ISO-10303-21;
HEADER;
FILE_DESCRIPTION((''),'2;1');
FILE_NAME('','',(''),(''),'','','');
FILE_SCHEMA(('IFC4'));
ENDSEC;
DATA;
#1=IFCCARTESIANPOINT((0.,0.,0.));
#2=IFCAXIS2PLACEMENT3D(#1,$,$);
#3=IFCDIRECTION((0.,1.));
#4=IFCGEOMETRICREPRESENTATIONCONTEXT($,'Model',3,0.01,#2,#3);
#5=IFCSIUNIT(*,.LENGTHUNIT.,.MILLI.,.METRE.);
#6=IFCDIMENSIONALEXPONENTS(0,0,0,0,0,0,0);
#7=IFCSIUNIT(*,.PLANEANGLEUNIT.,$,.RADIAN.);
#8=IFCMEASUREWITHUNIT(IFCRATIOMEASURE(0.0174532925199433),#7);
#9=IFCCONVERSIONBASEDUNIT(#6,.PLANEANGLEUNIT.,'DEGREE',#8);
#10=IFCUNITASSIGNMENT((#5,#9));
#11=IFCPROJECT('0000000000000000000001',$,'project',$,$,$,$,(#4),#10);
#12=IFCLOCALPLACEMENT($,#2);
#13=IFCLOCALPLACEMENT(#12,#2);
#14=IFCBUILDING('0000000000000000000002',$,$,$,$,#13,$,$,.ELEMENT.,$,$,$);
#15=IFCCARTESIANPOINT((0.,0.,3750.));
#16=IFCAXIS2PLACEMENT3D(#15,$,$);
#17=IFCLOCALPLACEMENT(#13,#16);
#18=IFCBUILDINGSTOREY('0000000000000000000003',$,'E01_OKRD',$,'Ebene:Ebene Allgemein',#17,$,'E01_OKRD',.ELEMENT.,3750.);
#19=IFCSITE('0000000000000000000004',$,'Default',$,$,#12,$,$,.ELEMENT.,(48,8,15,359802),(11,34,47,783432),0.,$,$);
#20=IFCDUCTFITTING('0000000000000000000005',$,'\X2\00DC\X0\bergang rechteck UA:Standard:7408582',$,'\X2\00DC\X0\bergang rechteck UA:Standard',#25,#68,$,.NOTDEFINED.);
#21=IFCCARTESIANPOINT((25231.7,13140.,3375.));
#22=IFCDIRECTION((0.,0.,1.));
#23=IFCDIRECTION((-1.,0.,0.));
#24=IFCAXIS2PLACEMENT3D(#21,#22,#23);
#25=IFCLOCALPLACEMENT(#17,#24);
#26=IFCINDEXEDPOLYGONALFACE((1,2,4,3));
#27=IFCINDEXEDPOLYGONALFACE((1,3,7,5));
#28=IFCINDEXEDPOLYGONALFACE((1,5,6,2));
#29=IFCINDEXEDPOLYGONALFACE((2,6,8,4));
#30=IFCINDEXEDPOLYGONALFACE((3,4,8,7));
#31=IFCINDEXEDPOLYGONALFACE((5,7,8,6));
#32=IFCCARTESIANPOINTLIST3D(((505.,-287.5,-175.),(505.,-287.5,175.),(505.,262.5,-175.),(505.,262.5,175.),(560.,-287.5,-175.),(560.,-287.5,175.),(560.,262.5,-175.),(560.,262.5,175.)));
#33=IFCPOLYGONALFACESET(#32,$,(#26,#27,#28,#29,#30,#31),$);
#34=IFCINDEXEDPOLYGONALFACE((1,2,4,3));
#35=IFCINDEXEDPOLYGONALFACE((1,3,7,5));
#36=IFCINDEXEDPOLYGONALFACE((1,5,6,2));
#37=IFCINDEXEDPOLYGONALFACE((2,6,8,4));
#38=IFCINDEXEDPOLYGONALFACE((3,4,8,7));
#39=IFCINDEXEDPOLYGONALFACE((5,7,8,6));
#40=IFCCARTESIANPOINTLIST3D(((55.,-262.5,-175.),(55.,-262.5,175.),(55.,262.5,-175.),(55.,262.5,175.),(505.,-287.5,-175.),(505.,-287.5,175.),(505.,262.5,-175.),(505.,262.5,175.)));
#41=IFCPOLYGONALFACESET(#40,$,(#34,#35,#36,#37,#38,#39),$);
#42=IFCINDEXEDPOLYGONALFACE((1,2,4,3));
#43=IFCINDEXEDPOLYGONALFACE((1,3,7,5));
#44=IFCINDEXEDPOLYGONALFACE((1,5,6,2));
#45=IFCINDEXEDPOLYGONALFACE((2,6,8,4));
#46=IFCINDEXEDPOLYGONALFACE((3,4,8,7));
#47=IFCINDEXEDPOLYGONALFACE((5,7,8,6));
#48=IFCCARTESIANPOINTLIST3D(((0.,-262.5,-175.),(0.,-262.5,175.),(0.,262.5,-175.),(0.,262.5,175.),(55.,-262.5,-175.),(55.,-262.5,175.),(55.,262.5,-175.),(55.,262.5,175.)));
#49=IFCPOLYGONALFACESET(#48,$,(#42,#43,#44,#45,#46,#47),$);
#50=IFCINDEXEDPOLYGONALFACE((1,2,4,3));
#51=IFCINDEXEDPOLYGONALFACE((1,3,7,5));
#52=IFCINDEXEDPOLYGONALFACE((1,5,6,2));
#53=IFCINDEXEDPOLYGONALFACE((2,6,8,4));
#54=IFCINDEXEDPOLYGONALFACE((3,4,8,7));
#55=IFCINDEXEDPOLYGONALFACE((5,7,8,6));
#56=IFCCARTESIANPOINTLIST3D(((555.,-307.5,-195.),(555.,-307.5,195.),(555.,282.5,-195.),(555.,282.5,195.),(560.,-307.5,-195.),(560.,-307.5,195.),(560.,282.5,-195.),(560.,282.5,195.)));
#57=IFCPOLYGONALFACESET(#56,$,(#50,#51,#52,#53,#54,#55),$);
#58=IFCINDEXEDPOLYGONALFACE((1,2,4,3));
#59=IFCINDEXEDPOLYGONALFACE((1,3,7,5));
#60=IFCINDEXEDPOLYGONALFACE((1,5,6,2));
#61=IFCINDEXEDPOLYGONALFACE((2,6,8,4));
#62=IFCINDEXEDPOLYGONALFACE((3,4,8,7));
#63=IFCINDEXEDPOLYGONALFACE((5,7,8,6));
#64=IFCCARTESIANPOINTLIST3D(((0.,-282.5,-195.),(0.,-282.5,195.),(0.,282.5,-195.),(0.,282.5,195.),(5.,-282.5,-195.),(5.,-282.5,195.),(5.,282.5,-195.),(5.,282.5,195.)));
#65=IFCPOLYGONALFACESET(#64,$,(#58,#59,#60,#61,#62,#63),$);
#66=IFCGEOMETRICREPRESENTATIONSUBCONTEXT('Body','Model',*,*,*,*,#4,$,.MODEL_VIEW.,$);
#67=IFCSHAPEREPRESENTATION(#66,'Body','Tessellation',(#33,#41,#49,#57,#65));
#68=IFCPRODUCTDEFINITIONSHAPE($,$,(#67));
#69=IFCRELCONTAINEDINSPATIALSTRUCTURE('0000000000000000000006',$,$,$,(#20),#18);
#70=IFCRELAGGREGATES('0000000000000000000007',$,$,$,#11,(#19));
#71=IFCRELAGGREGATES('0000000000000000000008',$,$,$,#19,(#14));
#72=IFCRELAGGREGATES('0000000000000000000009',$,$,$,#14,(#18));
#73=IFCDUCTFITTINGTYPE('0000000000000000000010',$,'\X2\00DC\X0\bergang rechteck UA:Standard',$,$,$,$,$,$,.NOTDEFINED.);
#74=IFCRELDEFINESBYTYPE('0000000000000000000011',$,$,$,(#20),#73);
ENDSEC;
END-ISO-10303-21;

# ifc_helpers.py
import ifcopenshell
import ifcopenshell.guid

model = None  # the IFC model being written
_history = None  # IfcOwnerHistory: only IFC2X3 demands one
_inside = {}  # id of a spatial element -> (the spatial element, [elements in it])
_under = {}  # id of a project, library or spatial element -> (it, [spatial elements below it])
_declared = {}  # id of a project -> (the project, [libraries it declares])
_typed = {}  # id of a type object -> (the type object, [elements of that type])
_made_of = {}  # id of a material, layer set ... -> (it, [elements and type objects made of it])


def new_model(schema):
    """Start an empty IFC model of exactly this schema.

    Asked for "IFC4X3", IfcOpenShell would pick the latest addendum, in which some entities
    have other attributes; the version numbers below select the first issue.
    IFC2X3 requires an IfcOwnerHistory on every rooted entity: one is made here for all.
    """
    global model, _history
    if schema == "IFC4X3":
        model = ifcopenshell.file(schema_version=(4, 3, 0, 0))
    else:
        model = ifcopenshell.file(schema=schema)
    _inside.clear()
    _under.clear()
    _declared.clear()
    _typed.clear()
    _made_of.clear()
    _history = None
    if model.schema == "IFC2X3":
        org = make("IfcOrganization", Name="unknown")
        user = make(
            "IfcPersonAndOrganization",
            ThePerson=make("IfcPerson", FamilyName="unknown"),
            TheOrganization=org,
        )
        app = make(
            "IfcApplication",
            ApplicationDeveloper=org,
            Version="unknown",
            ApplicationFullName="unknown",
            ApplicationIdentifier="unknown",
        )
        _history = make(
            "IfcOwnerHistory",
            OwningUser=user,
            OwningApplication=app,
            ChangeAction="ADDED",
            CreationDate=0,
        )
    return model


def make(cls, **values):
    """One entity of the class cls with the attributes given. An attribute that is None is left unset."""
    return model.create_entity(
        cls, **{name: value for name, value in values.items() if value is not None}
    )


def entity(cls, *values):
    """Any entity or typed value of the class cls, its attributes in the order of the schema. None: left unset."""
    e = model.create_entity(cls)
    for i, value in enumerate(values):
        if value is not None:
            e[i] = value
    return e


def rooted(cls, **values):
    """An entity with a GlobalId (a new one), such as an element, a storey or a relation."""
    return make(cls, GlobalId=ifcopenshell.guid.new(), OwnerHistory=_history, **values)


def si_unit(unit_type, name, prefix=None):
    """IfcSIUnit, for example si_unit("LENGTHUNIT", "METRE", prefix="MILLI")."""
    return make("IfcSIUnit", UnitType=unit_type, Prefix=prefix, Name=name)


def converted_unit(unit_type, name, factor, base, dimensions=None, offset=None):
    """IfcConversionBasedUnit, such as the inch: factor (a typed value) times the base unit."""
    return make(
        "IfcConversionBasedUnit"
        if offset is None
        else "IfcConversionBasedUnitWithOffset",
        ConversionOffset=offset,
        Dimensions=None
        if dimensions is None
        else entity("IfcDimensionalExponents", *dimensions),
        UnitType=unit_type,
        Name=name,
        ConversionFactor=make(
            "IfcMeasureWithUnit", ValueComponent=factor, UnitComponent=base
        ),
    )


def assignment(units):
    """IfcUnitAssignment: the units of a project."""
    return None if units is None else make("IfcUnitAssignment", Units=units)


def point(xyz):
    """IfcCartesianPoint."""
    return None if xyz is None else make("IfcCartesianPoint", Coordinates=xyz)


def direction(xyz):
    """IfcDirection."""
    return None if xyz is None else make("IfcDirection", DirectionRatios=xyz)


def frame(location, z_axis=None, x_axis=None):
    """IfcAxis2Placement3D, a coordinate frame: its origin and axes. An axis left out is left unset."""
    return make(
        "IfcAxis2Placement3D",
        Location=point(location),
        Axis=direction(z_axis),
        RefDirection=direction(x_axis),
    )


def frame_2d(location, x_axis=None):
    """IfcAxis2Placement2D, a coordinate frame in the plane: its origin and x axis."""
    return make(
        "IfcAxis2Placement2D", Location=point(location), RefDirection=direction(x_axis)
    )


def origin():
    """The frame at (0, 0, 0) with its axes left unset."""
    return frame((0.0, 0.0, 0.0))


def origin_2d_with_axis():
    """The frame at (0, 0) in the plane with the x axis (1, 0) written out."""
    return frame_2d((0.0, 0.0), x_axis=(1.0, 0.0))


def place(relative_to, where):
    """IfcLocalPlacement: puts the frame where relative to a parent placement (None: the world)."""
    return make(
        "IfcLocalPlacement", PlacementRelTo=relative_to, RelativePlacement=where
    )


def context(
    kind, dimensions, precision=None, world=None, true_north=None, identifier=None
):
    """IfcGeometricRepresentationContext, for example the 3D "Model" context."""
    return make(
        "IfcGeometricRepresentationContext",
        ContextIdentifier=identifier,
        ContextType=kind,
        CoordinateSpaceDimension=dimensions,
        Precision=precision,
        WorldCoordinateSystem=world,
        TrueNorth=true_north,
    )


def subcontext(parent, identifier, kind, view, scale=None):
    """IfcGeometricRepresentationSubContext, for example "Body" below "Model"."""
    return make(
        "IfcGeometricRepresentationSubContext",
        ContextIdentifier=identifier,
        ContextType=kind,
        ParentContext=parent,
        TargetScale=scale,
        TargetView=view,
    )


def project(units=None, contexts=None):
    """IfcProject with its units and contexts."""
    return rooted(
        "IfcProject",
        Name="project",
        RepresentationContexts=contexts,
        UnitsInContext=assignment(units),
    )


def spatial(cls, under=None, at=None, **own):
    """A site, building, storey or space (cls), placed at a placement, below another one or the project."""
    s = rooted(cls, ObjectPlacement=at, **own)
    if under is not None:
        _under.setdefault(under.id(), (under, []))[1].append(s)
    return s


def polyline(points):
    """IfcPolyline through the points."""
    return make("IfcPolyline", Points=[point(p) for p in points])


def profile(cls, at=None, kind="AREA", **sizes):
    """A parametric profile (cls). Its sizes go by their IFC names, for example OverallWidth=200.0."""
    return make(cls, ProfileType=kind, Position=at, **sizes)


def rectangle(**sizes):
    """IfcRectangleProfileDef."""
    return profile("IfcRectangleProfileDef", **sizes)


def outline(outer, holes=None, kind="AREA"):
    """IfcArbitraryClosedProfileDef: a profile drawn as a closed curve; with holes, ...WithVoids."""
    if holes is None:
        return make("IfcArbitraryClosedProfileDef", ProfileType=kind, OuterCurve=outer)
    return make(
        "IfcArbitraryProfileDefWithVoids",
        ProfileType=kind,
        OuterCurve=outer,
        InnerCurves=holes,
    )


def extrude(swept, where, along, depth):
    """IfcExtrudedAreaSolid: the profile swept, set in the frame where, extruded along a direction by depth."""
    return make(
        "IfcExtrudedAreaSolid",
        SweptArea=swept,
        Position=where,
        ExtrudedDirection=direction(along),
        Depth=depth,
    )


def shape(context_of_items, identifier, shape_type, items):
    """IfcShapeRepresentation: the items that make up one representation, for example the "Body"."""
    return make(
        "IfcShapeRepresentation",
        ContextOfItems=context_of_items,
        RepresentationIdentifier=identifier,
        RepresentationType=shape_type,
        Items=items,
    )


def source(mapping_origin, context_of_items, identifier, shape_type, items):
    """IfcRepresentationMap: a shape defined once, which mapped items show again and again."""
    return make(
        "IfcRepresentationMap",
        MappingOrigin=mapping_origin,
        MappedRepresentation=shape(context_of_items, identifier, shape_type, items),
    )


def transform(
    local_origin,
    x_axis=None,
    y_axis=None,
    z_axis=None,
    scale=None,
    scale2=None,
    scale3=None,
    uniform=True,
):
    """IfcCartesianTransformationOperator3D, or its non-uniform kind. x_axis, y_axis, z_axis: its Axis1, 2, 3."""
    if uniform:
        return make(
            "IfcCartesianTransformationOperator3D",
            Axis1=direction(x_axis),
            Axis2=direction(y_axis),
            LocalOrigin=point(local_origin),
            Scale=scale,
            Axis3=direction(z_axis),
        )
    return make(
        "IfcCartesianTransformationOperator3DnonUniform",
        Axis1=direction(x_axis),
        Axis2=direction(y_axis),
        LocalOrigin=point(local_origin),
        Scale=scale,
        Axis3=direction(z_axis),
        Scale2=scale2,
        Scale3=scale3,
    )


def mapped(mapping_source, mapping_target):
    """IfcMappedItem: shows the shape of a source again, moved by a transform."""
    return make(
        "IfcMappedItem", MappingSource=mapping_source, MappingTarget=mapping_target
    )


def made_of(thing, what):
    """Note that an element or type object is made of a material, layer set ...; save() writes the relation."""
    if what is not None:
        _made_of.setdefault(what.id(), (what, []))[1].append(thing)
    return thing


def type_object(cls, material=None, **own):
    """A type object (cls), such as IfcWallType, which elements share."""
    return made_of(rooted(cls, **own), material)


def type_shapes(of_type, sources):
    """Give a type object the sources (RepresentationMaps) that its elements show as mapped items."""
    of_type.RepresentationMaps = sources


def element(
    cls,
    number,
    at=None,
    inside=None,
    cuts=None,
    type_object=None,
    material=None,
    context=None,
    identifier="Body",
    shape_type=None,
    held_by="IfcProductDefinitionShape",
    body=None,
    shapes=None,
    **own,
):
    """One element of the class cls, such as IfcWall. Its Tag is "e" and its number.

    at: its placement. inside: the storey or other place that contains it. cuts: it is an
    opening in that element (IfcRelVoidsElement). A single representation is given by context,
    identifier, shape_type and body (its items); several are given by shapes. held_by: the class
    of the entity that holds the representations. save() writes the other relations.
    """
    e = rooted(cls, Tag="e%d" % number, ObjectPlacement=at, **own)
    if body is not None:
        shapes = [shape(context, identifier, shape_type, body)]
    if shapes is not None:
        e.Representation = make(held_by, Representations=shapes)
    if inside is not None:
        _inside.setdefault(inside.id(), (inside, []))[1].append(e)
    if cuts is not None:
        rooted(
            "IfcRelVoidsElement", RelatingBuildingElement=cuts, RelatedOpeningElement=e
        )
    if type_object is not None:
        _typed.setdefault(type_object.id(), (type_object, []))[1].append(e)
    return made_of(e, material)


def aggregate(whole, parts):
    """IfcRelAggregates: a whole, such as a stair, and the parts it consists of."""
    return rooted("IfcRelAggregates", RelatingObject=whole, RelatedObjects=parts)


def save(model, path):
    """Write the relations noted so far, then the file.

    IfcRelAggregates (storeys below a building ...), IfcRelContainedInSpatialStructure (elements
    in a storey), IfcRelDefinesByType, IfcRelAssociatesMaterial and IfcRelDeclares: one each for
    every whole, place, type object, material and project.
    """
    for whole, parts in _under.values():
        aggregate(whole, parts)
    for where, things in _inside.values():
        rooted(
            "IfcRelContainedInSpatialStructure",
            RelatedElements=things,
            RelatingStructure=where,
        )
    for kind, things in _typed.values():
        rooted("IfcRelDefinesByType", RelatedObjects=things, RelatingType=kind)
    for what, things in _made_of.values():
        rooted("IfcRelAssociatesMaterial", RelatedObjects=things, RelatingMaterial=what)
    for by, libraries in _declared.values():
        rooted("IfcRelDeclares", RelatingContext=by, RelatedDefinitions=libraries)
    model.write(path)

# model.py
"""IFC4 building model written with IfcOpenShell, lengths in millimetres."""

from ifc_helpers import new_model, entity, si_unit, converted_unit, direction, frame, frame_2d, origin, origin_2d_with_axis, place, context, subcontext, project, spatial, polyline, rectangle, outline, extrude, source, transform, mapped, type_object, type_shapes, element, save


model = new_model("IFC4")

# Units and contexts
model_context = context("Model", 3, precision=0.01, world=origin(), true_north=direction((0.0, 1.0)))
body_context = subcontext(model_context, "Body", "Model", "MODEL_VIEW")
ifc_project = project(units=[si_unit("LENGTHUNIT", "METRE", prefix="MILLI"), converted_unit("PLANEANGLEUNIT", "DEGREE", entity("IfcRatioMeasure", 0.0174532925199433), si_unit("PLANEANGLEUNIT", "RADIAN"), dimensions=[0, 0, 0, 0, 0, 0, 0])], contexts=[model_context])

# Site, building, storey
site_placement = place(None, origin())
site = spatial("IfcSite", under=ifc_project, at=site_placement, Name="Default", CompositionType="ELEMENT", RefLatitude=(48, 8, 15, 359802), RefLongitude=(11, 34, 47, 783432), RefElevation=0.0)
building_placement = place(site_placement, origin())
building = spatial("IfcBuilding", under=site, at=building_placement, CompositionType="ELEMENT")
storey_placement = place(building_placement, frame((0.0, 0.0, 3750.0)))
storey = spatial("IfcBuildingStorey", under=building, at=storey_placement, Name="E01_OKRD", ObjectType="Ebene:Ebene Allgemein", LongName="E01_OKRD", CompositionType="ELEMENT", Elevation=3750.0)

# Duct fitting
duct_fitting_type_1 = type_object("IfcDuctFittingType", Name="Übergang rechteck UA:Standard", PredefinedType="NOTDEFINED")
shared_shape_1 = source(origin(), body_context, "Body", "SweptSolid", [
    extrude(rectangle(XDim=55.0, YDim=550.0, at=frame_2d((0.0, 0.0), x_axis=(1.0, 0.0))), frame((532.5, -12.5, -175.0)), (0.0, 0.0, 1.0), 350.0),
    extrude(outline(polyline([(-210.4, -268.3), (240.3, -268.3), (209.7, 280.8), (-239.6, 255.9), (-210.4, -268.3)])), frame((280.0, -6.2, -175.0), z_axis=(0.0, 0.0, 1.0), x_axis=(0.99846, -0.05547, 0.0)), (0.0, 0.0, 1.0), 350.0),
    extrude(rectangle(XDim=55.0, YDim=525.0, at=frame_2d((0.0, 0.0), x_axis=(1.0, 0.0))), frame((27.5, 0.0, -175.0)), (0.0, 0.0, 1.0), 350.0),
    extrude(rectangle(XDim=5.0, YDim=590.0, at=origin_2d_with_axis()), frame((557.5, -12.5, -195.0)), (0.0, 0.0, 1.0), 390.0),
    extrude(rectangle(XDim=5.0, YDim=565.0, at=frame_2d((0.0, 0.0), x_axis=(1.0, 0.0))), frame((2.5, 0.0, -195.0)), (0.0, 0.0, 1.0), 390.0),
])
type_shapes(duct_fitting_type_1, [shared_shape_1])
duct_fitting_1_placement = place(storey_placement, frame((25231.7, 13140.0, 3375.0), z_axis=(0.0, 0.0, 1.0), x_axis=(-1.0, 0.0, 0.0)))
element("IfcDuctFitting", 1, at=duct_fitting_1_placement, inside=storey, type_object=duct_fitting_type_1, Name="Übergang rechteck UA:Standard:7408582", ObjectType="Übergang rechteck UA:Standard", PredefinedType="NOTDEFINED", context=body_context, shape_type="MappedRepresentation", body=[
    mapped(shared_shape_1, transform((0.0, 0.0, 0.0), scale=1.0)),
])

save(model, "model.ifc")
